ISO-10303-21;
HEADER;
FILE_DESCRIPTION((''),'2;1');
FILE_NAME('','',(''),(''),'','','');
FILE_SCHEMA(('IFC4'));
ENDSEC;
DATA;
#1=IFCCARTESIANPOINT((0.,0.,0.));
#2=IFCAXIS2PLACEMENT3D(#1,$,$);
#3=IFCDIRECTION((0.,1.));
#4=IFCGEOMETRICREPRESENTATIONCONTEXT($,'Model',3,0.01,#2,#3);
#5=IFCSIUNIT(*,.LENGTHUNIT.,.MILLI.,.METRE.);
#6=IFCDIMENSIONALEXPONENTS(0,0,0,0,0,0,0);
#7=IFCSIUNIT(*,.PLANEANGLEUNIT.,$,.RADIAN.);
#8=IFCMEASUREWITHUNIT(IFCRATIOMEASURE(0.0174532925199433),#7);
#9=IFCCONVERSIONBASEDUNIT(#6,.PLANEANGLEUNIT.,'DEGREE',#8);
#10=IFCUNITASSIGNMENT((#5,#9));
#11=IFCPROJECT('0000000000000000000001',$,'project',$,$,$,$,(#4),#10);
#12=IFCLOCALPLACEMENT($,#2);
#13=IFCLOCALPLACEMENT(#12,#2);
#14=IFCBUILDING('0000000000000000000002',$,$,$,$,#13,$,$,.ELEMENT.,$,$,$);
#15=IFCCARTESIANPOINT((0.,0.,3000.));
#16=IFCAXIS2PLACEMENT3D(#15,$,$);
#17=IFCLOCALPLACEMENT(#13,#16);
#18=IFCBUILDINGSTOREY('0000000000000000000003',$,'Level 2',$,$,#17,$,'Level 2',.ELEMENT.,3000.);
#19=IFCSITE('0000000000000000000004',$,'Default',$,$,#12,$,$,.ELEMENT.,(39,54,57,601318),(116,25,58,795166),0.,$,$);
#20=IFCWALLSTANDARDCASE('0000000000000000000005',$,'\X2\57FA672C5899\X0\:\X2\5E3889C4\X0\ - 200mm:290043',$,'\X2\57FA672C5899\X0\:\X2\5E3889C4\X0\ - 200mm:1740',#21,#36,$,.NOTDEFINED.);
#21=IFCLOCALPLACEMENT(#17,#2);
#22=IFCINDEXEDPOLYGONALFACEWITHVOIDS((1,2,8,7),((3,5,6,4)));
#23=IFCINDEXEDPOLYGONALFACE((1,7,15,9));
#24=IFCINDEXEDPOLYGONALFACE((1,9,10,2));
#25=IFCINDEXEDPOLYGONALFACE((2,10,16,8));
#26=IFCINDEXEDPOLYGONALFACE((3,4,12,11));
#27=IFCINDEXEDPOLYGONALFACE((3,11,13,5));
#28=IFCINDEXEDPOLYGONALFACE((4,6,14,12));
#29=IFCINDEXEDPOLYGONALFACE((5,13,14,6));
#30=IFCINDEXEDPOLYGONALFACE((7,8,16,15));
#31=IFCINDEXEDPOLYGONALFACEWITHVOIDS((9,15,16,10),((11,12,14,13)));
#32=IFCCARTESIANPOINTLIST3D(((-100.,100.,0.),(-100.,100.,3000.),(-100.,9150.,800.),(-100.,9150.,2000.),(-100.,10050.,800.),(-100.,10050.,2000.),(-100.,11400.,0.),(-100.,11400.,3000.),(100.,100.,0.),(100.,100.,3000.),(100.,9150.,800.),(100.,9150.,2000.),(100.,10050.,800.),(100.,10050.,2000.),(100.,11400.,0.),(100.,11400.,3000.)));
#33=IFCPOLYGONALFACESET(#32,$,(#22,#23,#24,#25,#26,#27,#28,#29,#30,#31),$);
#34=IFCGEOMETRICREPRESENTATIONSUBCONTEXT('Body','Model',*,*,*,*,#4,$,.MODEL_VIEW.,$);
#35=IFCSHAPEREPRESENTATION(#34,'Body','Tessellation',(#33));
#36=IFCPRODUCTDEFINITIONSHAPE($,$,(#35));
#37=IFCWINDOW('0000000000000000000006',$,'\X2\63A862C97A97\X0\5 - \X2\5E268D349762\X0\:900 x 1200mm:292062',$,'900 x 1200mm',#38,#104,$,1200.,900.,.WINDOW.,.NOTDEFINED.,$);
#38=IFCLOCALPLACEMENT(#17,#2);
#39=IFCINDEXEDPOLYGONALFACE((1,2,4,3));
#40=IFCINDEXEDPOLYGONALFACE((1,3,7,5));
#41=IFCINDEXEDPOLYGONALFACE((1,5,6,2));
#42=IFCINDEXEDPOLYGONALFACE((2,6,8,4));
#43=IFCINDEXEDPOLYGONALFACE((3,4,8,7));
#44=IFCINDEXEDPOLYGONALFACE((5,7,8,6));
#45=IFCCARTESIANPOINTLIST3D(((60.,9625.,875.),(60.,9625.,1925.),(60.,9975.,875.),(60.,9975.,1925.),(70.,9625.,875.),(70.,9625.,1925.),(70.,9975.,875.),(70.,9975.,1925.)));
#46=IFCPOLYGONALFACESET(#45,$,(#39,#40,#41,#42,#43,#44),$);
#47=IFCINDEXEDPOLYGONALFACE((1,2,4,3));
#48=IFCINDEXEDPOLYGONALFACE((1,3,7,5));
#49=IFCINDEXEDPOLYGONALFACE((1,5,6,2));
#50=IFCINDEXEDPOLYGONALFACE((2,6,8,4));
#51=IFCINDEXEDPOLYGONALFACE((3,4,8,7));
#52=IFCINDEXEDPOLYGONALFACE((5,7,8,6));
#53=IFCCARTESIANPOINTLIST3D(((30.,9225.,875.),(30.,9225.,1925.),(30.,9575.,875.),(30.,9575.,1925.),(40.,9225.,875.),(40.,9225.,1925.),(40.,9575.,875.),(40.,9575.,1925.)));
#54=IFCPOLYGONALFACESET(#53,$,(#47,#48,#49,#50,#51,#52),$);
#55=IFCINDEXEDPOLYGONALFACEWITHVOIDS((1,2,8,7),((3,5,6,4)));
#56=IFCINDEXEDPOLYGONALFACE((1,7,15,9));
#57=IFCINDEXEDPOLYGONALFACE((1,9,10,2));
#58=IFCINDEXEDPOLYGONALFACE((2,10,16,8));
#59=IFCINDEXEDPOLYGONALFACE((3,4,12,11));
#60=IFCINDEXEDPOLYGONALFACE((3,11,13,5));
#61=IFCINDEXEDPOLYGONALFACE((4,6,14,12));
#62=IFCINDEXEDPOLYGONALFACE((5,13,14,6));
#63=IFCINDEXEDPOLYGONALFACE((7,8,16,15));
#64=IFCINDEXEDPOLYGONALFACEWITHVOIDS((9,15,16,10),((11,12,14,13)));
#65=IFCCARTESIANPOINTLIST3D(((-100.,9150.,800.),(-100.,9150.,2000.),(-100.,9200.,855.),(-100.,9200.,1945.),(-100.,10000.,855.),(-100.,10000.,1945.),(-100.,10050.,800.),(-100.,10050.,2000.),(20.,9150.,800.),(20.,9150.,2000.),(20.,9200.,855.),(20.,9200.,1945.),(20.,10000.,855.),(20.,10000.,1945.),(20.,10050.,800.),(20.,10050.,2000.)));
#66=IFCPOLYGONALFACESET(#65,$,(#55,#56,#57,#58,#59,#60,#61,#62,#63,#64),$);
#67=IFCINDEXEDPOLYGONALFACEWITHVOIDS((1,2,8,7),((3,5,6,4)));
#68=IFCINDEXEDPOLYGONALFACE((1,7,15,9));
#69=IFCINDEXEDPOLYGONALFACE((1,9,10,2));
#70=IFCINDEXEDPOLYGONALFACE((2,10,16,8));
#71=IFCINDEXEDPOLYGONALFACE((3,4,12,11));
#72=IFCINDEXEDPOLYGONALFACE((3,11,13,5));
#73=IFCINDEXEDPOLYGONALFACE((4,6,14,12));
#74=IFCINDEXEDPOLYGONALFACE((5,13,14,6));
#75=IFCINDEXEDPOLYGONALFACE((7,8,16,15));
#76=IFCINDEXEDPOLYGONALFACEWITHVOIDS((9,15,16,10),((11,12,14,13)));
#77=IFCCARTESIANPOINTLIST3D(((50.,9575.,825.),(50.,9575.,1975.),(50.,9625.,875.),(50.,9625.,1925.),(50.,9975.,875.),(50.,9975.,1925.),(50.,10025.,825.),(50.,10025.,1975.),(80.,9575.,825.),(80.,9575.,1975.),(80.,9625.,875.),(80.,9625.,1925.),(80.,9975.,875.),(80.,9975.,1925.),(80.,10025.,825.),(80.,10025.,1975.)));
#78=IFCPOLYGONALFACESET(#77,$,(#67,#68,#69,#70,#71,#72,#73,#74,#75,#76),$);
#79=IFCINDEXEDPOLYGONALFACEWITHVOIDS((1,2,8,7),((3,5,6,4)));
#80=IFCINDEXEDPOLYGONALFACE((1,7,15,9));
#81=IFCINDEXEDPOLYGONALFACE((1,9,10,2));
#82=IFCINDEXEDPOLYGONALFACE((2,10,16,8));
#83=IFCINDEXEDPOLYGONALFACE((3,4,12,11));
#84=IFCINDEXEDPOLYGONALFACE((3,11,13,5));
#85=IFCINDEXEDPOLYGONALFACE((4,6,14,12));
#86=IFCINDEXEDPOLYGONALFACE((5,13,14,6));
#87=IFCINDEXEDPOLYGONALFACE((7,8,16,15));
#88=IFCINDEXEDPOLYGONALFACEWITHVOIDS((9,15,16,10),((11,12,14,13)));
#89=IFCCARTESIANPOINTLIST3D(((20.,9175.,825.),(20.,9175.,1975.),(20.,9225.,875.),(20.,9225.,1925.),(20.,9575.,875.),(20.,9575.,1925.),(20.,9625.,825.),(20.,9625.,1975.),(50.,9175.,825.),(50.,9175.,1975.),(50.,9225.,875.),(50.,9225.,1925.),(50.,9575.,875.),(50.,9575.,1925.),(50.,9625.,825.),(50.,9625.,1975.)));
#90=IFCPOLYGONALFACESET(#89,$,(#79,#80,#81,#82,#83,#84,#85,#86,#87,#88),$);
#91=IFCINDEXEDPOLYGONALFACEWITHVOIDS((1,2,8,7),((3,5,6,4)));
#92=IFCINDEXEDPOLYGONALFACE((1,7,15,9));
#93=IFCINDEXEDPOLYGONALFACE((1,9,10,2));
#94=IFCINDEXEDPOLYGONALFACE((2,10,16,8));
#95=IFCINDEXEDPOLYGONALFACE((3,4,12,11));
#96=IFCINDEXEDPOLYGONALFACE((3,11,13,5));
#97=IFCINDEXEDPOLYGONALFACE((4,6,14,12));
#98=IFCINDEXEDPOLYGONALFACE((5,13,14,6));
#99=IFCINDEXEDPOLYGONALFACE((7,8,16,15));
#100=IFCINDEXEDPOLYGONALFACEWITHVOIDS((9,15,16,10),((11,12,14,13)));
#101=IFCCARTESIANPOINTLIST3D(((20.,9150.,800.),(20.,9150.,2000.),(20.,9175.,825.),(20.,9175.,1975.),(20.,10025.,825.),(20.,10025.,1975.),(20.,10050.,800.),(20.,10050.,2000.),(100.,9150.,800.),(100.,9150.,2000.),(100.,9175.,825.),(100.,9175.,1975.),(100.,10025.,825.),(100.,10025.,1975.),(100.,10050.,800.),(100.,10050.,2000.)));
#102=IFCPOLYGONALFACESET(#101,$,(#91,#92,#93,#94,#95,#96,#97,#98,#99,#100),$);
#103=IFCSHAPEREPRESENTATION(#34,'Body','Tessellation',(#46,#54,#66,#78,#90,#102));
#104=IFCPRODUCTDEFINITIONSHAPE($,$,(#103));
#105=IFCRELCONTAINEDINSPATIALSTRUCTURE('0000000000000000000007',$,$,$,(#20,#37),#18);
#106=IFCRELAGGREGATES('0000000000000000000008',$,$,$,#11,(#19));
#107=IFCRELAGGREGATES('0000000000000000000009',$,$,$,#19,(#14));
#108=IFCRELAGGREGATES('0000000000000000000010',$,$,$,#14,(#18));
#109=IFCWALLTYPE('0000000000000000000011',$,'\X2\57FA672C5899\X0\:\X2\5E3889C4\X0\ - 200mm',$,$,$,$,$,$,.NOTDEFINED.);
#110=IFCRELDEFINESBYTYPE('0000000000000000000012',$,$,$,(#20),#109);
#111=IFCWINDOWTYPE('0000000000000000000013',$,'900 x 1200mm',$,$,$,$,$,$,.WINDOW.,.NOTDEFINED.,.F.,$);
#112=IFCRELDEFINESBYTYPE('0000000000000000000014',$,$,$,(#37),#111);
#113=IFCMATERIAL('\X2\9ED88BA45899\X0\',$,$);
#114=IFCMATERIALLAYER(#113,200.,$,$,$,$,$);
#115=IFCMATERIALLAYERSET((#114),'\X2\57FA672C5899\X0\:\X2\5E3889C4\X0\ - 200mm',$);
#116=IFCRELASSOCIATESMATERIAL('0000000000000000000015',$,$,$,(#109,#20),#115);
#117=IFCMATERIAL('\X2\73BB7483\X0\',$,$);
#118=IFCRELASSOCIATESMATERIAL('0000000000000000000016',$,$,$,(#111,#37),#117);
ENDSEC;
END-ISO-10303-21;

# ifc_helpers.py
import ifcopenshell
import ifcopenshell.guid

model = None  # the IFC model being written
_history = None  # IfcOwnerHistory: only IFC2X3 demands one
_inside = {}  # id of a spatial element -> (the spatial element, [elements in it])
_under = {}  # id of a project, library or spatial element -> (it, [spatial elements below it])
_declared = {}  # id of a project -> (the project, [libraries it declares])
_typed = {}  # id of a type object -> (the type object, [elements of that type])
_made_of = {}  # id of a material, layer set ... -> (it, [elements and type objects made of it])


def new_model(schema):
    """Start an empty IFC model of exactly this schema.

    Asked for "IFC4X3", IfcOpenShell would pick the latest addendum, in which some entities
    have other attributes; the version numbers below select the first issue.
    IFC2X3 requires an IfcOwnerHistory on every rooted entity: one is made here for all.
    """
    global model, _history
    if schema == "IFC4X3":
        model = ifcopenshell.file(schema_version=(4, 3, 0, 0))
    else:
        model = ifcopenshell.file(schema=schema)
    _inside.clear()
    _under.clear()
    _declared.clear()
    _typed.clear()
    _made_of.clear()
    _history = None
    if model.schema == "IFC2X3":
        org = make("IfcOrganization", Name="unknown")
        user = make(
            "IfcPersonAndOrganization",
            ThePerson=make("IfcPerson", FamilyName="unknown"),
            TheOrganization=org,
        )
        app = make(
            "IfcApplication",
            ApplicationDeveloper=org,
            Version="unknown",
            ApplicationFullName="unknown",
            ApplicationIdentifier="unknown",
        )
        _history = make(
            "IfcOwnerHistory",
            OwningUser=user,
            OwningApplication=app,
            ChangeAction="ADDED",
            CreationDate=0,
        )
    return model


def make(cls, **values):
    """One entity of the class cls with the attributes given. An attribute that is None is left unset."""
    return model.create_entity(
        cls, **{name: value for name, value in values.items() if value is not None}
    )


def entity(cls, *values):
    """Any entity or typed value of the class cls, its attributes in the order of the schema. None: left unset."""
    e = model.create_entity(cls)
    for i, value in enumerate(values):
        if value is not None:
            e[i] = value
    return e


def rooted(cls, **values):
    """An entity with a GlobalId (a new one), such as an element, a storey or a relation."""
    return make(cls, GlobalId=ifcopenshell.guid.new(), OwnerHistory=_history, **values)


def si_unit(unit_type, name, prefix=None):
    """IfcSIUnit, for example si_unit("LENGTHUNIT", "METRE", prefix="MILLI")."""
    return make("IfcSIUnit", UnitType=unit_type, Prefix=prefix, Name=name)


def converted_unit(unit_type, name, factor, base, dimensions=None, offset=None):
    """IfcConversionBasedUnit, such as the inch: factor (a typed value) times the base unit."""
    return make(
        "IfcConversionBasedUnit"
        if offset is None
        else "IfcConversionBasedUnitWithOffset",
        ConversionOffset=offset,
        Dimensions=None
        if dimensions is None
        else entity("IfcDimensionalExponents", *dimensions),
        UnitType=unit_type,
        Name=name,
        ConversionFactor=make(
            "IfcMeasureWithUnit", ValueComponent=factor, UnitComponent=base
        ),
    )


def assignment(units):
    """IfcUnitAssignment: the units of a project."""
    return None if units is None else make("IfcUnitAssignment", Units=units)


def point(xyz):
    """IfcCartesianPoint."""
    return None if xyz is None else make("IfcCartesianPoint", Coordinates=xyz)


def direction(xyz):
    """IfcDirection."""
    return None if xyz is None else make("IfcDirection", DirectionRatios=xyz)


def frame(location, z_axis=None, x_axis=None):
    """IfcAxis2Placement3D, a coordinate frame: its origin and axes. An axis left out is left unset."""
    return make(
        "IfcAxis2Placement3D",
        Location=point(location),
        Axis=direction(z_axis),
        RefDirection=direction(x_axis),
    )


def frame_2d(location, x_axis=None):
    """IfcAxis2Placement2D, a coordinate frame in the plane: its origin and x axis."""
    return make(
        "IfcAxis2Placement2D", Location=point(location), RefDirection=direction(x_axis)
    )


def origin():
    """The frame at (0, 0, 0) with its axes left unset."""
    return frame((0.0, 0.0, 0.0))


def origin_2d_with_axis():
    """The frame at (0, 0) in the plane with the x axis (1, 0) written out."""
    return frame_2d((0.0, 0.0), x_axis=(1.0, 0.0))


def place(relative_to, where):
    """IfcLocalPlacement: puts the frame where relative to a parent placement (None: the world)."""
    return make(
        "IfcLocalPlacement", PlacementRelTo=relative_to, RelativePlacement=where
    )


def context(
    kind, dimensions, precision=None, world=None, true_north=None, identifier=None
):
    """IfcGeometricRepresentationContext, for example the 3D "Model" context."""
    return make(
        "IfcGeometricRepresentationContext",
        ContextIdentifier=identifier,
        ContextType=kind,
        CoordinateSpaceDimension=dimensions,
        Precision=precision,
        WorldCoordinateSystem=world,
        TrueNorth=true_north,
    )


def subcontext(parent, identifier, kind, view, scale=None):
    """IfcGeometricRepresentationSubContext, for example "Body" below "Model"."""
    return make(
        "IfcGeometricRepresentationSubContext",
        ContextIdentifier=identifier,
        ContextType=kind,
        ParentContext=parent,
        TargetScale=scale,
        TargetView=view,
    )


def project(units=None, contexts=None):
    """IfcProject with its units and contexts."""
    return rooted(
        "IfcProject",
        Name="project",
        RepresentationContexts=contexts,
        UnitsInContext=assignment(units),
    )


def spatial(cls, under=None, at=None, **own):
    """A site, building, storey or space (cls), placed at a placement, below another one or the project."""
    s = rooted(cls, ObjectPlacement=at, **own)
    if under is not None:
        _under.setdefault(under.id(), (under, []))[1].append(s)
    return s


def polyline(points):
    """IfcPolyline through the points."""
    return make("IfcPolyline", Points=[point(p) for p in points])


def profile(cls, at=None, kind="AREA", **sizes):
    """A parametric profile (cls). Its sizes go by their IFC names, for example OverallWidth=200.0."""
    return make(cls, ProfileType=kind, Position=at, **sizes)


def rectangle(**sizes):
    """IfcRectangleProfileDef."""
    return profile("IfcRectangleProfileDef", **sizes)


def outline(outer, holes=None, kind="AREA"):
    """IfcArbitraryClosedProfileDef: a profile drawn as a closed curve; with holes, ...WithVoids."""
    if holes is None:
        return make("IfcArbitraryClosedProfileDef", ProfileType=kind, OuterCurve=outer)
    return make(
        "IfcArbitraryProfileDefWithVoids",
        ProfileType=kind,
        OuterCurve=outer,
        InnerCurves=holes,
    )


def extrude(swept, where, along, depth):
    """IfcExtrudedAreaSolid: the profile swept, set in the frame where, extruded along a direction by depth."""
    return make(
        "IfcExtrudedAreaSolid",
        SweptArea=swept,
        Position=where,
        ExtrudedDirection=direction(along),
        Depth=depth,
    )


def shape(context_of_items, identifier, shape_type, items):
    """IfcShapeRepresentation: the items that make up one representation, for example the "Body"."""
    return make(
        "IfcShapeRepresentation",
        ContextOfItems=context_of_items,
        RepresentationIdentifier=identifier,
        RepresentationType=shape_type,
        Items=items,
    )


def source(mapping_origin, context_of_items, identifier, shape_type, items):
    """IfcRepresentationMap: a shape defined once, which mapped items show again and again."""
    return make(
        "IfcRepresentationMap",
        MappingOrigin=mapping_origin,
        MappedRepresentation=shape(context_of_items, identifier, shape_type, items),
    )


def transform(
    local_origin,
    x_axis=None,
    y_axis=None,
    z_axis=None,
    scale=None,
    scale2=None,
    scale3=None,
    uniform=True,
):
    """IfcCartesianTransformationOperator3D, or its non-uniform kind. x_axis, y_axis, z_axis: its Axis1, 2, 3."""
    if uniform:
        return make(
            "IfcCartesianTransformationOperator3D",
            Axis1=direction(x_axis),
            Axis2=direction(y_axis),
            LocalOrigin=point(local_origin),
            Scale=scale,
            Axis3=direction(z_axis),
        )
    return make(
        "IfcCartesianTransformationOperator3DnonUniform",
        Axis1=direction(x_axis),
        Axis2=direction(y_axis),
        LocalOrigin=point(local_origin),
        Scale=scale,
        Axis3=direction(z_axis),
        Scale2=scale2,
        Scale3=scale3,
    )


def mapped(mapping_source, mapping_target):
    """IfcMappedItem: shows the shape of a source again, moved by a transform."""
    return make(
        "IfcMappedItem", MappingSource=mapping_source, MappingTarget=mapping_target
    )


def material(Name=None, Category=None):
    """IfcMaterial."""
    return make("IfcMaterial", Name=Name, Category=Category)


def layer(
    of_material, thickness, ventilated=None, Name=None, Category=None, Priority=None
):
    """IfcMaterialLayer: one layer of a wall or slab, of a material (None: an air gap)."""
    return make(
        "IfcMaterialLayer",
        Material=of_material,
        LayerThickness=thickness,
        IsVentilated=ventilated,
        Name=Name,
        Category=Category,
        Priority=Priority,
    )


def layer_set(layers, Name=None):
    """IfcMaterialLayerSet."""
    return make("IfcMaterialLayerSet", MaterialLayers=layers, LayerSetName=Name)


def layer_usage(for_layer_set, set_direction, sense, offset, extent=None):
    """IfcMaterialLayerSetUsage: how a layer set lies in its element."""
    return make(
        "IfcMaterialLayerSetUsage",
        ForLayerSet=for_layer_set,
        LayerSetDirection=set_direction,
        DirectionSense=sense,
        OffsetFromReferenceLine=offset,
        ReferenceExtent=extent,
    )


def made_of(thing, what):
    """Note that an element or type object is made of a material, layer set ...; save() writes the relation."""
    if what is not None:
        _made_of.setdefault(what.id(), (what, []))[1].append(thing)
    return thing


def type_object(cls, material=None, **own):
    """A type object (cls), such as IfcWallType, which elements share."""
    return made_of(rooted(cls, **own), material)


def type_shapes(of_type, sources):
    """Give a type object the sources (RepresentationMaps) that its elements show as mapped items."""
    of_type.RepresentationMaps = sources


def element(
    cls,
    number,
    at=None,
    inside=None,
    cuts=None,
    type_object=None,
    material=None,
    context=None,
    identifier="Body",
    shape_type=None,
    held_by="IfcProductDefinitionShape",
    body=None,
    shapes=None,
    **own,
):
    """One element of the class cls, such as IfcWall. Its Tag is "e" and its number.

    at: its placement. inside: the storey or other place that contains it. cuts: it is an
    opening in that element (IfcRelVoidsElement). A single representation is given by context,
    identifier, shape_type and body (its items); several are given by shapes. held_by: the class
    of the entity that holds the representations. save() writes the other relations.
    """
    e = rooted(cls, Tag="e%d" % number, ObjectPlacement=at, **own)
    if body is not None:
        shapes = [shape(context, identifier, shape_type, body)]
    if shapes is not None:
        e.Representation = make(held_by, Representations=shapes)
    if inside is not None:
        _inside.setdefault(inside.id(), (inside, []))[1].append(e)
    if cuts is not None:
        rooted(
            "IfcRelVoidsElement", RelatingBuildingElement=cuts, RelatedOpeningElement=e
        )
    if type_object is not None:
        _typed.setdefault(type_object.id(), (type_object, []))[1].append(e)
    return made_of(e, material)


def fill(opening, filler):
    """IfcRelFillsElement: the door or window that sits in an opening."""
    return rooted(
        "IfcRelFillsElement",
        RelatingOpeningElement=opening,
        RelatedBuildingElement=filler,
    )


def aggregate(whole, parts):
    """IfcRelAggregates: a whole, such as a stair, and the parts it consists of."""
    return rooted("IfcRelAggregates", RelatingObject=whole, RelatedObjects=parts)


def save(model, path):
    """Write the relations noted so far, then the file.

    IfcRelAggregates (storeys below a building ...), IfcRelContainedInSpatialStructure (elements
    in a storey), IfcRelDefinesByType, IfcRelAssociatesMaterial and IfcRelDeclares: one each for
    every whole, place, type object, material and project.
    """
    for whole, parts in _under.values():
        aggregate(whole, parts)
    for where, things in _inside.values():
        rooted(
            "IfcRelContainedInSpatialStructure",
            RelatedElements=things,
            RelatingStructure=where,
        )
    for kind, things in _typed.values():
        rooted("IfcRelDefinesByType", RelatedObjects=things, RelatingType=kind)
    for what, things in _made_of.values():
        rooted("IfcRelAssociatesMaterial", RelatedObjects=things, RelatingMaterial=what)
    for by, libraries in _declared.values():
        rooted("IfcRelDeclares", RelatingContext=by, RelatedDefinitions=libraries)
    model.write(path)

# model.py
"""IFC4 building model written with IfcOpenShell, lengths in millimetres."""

from ifc_helpers import new_model, entity, si_unit, converted_unit, direction, frame, frame_2d, origin, origin_2d_with_axis, place, context, subcontext, project, spatial, polyline, rectangle, outline, extrude, source, transform, mapped, material, layer, layer_set, layer_usage, type_object, type_shapes, element, fill, save


model = new_model("IFC4")

# Units and contexts
model_context = context("Model", 3, precision=0.01, world=origin(), true_north=direction((0.0, 1.0)))
body_context = subcontext(model_context, "Body", "Model", "MODEL_VIEW")
ifc_project = project(units=[si_unit("LENGTHUNIT", "METRE", prefix="MILLI"), converted_unit("PLANEANGLEUNIT", "DEGREE", entity("IfcRatioMeasure", 0.0174532925199433), si_unit("PLANEANGLEUNIT", "RADIAN"), dimensions=[0, 0, 0, 0, 0, 0, 0])], contexts=[model_context])

# Site, building, storey
site_placement = place(None, origin())
site = spatial("IfcSite", under=ifc_project, at=site_placement, Name="Default", CompositionType="ELEMENT", RefLatitude=(39, 54, 57, 601318), RefLongitude=(116, 25, 58, 795166), RefElevation=0.0)
building_placement = place(site_placement, origin())
building = spatial("IfcBuilding", under=site, at=building_placement, CompositionType="ELEMENT")
storey_placement = place(building_placement, frame((0.0, 0.0, 3000.0)))
storey = spatial("IfcBuildingStorey", under=building, at=storey_placement, Name="Level 2", LongName="Level 2", CompositionType="ELEMENT", Elevation=3000.0)

# Shared definitions
ifc_material_1 = material(Name="默认墙")
ifc_layer_1 = layer(ifc_material_1, 200.0)
ifc_layer_set_1 = layer_set([ifc_layer_1], Name="基本墙:常规 - 200mm")
wall_type = type_object("IfcWallType", Name="基本墙:常规 - 200mm", PredefinedType="NOTDEFINED", material=ifc_layer_set_1)

# Wall, opening, window
ifc_material_2 = material(Name="玻璃")
window_type = type_object("IfcWindowType", Name="900 x 1200mm", ParameterTakesPrecedence=False, PartitioningType="NOTDEFINED", PredefinedType="WINDOW", material=ifc_material_2)
shared_shape_1 = source(origin(), body_context, "Body", "SweptSolid", [
    extrude(rectangle(XDim=10.0, YDim=350.0, at=origin_2d_with_axis()), frame((250.0, 165.0, 75.0), z_axis=(0.0, 0.0, 1.0), x_axis=(0.0, -1.0, 0.0)), (0.0, 0.0, 1.0), 1050.0),
    extrude(rectangle(XDim=10.0, YDim=350.0, at=frame_2d((0.0, 0.0), x_axis=(1.0, 0.0))), frame((650.0, 135.0, 75.0), z_axis=(0.0, 0.0, 1.0), x_axis=(0.0, -1.0, 0.0)), (0.0, 0.0, 1.0), 1050.0),
    extrude(outline(polyline([(-450.0, -600.0), (450.0, -600.0), (450.0, 600.0), (-450.0, 600.0), (-450.0, -600.0)]), holes=[polyline([(400.0, -545.0), (-400.0, -545.0), (-400.0, 545.0), (400.0, 545.0), (400.0, -545.0)])]), frame((450.0, 0.0, 600.0), z_axis=(0.0, 1.0, 0.0), x_axis=(1.0, 0.0, 0.0)), (0.0, 0.0, 1.0), 120.0),
    extrude(outline(polyline([(-225.0, -575.0), (225.0, -575.0), (225.0, 575.0), (-225.0, 575.0), (-225.0, -575.0)]), holes=[polyline([(-175.0, -525.0), (-175.0, 525.0), (175.0, 525.0), (175.0, -525.0), (-175.0, -525.0)])]), frame((250.0, 150.0, 600.0), z_axis=(0.0, 1.0, 0.0), x_axis=(-1.0, 0.0, 0.0)), (0.0, 0.0, 1.0), 30.0),
    extrude(outline(polyline([(-225.0, -575.0), (225.0, -575.0), (225.0, 575.0), (-225.0, 575.0), (-225.0, -575.0)]), holes=[polyline([(-175.0, -525.0), (-175.0, 525.0), (175.0, 525.0), (175.0, -525.0), (-175.0, -525.0)])]), frame((650.0, 120.0, 600.0), z_axis=(0.0, 1.0, 0.0), x_axis=(1.0, 0.0, 0.0)), (0.0, 0.0, 1.0), 30.0),
    extrude(outline(polyline([(-450.0, -600.0), (450.0, -600.0), (450.0, 600.0), (-450.0, 600.0), (-450.0, -600.0)]), holes=[polyline([(-425.0, 575.0), (425.0, 575.0), (425.0, -575.0), (-425.0, -575.0), (-425.0, 575.0)])]), frame((450.0, 120.0, 600.0), z_axis=(0.0, 1.0, 0.0), x_axis=(1.0, 0.0, 0.0)), (0.0, 0.0, 1.0), 80.0),
])
type_shapes(window_type, [shared_shape_1])
ifc_layer_usage_1 = layer_usage(ifc_layer_set_1, "AXIS2", "NEGATIVE", 100.0)
wall_1_placement = place(storey_placement, frame((0.0, 100.0, 0.0), z_axis=(0.0, 0.0, 1.0), x_axis=(0.0, 1.0, 0.0)))
wall_1 = element("IfcWallStandardCase", 1, at=wall_1_placement, inside=storey, type_object=wall_type, material=ifc_layer_usage_1, Name="基本墙:常规 - 200mm:290043", ObjectType="基本墙:常规 - 200mm:1740", PredefinedType="NOTDEFINED", context=body_context, shape_type="SweptSolid", body=[
    extrude(rectangle(XDim=11300.0, YDim=200.0, at=frame_2d((5650.0, 0.0), x_axis=(-1.0, 0.0))), origin(), (0.0, 0.0, 1.0), 3000.0),
])
opening_1_placement = place(wall_1_placement, frame((9950.0, 100.0, 800.0)))
opening_1 = element("IfcOpeningElement", 2, at=opening_1_placement, cuts=wall_1, ObjectType="Opening", PredefinedType="OPENING", context=body_context, shape_type="SweptSolid", body=[
    extrude(rectangle(XDim=1200.0, YDim=900.0, at=frame_2d((600.0, 450.0), x_axis=(-1.0, 0.0))), frame((0.0, 0.0, 0.0), z_axis=(0.0, -1.0, 0.0), x_axis=(0.0, 0.0, 1.0)), (0.0, 0.0, 1.0), 200.0),
])
window_1_placement = place(opening_1_placement, frame((0.0, 0.0, 0.0), z_axis=(0.0, 0.0, 1.0), x_axis=(-1.0, 0.0, 0.0)))
window_1 = element("IfcWindow", 3, at=window_1_placement, inside=storey, type_object=window_type, material=ifc_material_2, Name="推拉窗5 - 带贴面:900 x 1200mm:292062", ObjectType="900 x 1200mm", OverallHeight=1200.0, OverallWidth=900.0, PartitioningType="NOTDEFINED", PredefinedType="WINDOW", context=body_context, shape_type="MappedRepresentation", body=[
    mapped(shared_shape_1, transform((0.0, 0.0, 0.0), scale=1.0)),
])
fill(opening_1, window_1)

save(model, "model.ifc")
